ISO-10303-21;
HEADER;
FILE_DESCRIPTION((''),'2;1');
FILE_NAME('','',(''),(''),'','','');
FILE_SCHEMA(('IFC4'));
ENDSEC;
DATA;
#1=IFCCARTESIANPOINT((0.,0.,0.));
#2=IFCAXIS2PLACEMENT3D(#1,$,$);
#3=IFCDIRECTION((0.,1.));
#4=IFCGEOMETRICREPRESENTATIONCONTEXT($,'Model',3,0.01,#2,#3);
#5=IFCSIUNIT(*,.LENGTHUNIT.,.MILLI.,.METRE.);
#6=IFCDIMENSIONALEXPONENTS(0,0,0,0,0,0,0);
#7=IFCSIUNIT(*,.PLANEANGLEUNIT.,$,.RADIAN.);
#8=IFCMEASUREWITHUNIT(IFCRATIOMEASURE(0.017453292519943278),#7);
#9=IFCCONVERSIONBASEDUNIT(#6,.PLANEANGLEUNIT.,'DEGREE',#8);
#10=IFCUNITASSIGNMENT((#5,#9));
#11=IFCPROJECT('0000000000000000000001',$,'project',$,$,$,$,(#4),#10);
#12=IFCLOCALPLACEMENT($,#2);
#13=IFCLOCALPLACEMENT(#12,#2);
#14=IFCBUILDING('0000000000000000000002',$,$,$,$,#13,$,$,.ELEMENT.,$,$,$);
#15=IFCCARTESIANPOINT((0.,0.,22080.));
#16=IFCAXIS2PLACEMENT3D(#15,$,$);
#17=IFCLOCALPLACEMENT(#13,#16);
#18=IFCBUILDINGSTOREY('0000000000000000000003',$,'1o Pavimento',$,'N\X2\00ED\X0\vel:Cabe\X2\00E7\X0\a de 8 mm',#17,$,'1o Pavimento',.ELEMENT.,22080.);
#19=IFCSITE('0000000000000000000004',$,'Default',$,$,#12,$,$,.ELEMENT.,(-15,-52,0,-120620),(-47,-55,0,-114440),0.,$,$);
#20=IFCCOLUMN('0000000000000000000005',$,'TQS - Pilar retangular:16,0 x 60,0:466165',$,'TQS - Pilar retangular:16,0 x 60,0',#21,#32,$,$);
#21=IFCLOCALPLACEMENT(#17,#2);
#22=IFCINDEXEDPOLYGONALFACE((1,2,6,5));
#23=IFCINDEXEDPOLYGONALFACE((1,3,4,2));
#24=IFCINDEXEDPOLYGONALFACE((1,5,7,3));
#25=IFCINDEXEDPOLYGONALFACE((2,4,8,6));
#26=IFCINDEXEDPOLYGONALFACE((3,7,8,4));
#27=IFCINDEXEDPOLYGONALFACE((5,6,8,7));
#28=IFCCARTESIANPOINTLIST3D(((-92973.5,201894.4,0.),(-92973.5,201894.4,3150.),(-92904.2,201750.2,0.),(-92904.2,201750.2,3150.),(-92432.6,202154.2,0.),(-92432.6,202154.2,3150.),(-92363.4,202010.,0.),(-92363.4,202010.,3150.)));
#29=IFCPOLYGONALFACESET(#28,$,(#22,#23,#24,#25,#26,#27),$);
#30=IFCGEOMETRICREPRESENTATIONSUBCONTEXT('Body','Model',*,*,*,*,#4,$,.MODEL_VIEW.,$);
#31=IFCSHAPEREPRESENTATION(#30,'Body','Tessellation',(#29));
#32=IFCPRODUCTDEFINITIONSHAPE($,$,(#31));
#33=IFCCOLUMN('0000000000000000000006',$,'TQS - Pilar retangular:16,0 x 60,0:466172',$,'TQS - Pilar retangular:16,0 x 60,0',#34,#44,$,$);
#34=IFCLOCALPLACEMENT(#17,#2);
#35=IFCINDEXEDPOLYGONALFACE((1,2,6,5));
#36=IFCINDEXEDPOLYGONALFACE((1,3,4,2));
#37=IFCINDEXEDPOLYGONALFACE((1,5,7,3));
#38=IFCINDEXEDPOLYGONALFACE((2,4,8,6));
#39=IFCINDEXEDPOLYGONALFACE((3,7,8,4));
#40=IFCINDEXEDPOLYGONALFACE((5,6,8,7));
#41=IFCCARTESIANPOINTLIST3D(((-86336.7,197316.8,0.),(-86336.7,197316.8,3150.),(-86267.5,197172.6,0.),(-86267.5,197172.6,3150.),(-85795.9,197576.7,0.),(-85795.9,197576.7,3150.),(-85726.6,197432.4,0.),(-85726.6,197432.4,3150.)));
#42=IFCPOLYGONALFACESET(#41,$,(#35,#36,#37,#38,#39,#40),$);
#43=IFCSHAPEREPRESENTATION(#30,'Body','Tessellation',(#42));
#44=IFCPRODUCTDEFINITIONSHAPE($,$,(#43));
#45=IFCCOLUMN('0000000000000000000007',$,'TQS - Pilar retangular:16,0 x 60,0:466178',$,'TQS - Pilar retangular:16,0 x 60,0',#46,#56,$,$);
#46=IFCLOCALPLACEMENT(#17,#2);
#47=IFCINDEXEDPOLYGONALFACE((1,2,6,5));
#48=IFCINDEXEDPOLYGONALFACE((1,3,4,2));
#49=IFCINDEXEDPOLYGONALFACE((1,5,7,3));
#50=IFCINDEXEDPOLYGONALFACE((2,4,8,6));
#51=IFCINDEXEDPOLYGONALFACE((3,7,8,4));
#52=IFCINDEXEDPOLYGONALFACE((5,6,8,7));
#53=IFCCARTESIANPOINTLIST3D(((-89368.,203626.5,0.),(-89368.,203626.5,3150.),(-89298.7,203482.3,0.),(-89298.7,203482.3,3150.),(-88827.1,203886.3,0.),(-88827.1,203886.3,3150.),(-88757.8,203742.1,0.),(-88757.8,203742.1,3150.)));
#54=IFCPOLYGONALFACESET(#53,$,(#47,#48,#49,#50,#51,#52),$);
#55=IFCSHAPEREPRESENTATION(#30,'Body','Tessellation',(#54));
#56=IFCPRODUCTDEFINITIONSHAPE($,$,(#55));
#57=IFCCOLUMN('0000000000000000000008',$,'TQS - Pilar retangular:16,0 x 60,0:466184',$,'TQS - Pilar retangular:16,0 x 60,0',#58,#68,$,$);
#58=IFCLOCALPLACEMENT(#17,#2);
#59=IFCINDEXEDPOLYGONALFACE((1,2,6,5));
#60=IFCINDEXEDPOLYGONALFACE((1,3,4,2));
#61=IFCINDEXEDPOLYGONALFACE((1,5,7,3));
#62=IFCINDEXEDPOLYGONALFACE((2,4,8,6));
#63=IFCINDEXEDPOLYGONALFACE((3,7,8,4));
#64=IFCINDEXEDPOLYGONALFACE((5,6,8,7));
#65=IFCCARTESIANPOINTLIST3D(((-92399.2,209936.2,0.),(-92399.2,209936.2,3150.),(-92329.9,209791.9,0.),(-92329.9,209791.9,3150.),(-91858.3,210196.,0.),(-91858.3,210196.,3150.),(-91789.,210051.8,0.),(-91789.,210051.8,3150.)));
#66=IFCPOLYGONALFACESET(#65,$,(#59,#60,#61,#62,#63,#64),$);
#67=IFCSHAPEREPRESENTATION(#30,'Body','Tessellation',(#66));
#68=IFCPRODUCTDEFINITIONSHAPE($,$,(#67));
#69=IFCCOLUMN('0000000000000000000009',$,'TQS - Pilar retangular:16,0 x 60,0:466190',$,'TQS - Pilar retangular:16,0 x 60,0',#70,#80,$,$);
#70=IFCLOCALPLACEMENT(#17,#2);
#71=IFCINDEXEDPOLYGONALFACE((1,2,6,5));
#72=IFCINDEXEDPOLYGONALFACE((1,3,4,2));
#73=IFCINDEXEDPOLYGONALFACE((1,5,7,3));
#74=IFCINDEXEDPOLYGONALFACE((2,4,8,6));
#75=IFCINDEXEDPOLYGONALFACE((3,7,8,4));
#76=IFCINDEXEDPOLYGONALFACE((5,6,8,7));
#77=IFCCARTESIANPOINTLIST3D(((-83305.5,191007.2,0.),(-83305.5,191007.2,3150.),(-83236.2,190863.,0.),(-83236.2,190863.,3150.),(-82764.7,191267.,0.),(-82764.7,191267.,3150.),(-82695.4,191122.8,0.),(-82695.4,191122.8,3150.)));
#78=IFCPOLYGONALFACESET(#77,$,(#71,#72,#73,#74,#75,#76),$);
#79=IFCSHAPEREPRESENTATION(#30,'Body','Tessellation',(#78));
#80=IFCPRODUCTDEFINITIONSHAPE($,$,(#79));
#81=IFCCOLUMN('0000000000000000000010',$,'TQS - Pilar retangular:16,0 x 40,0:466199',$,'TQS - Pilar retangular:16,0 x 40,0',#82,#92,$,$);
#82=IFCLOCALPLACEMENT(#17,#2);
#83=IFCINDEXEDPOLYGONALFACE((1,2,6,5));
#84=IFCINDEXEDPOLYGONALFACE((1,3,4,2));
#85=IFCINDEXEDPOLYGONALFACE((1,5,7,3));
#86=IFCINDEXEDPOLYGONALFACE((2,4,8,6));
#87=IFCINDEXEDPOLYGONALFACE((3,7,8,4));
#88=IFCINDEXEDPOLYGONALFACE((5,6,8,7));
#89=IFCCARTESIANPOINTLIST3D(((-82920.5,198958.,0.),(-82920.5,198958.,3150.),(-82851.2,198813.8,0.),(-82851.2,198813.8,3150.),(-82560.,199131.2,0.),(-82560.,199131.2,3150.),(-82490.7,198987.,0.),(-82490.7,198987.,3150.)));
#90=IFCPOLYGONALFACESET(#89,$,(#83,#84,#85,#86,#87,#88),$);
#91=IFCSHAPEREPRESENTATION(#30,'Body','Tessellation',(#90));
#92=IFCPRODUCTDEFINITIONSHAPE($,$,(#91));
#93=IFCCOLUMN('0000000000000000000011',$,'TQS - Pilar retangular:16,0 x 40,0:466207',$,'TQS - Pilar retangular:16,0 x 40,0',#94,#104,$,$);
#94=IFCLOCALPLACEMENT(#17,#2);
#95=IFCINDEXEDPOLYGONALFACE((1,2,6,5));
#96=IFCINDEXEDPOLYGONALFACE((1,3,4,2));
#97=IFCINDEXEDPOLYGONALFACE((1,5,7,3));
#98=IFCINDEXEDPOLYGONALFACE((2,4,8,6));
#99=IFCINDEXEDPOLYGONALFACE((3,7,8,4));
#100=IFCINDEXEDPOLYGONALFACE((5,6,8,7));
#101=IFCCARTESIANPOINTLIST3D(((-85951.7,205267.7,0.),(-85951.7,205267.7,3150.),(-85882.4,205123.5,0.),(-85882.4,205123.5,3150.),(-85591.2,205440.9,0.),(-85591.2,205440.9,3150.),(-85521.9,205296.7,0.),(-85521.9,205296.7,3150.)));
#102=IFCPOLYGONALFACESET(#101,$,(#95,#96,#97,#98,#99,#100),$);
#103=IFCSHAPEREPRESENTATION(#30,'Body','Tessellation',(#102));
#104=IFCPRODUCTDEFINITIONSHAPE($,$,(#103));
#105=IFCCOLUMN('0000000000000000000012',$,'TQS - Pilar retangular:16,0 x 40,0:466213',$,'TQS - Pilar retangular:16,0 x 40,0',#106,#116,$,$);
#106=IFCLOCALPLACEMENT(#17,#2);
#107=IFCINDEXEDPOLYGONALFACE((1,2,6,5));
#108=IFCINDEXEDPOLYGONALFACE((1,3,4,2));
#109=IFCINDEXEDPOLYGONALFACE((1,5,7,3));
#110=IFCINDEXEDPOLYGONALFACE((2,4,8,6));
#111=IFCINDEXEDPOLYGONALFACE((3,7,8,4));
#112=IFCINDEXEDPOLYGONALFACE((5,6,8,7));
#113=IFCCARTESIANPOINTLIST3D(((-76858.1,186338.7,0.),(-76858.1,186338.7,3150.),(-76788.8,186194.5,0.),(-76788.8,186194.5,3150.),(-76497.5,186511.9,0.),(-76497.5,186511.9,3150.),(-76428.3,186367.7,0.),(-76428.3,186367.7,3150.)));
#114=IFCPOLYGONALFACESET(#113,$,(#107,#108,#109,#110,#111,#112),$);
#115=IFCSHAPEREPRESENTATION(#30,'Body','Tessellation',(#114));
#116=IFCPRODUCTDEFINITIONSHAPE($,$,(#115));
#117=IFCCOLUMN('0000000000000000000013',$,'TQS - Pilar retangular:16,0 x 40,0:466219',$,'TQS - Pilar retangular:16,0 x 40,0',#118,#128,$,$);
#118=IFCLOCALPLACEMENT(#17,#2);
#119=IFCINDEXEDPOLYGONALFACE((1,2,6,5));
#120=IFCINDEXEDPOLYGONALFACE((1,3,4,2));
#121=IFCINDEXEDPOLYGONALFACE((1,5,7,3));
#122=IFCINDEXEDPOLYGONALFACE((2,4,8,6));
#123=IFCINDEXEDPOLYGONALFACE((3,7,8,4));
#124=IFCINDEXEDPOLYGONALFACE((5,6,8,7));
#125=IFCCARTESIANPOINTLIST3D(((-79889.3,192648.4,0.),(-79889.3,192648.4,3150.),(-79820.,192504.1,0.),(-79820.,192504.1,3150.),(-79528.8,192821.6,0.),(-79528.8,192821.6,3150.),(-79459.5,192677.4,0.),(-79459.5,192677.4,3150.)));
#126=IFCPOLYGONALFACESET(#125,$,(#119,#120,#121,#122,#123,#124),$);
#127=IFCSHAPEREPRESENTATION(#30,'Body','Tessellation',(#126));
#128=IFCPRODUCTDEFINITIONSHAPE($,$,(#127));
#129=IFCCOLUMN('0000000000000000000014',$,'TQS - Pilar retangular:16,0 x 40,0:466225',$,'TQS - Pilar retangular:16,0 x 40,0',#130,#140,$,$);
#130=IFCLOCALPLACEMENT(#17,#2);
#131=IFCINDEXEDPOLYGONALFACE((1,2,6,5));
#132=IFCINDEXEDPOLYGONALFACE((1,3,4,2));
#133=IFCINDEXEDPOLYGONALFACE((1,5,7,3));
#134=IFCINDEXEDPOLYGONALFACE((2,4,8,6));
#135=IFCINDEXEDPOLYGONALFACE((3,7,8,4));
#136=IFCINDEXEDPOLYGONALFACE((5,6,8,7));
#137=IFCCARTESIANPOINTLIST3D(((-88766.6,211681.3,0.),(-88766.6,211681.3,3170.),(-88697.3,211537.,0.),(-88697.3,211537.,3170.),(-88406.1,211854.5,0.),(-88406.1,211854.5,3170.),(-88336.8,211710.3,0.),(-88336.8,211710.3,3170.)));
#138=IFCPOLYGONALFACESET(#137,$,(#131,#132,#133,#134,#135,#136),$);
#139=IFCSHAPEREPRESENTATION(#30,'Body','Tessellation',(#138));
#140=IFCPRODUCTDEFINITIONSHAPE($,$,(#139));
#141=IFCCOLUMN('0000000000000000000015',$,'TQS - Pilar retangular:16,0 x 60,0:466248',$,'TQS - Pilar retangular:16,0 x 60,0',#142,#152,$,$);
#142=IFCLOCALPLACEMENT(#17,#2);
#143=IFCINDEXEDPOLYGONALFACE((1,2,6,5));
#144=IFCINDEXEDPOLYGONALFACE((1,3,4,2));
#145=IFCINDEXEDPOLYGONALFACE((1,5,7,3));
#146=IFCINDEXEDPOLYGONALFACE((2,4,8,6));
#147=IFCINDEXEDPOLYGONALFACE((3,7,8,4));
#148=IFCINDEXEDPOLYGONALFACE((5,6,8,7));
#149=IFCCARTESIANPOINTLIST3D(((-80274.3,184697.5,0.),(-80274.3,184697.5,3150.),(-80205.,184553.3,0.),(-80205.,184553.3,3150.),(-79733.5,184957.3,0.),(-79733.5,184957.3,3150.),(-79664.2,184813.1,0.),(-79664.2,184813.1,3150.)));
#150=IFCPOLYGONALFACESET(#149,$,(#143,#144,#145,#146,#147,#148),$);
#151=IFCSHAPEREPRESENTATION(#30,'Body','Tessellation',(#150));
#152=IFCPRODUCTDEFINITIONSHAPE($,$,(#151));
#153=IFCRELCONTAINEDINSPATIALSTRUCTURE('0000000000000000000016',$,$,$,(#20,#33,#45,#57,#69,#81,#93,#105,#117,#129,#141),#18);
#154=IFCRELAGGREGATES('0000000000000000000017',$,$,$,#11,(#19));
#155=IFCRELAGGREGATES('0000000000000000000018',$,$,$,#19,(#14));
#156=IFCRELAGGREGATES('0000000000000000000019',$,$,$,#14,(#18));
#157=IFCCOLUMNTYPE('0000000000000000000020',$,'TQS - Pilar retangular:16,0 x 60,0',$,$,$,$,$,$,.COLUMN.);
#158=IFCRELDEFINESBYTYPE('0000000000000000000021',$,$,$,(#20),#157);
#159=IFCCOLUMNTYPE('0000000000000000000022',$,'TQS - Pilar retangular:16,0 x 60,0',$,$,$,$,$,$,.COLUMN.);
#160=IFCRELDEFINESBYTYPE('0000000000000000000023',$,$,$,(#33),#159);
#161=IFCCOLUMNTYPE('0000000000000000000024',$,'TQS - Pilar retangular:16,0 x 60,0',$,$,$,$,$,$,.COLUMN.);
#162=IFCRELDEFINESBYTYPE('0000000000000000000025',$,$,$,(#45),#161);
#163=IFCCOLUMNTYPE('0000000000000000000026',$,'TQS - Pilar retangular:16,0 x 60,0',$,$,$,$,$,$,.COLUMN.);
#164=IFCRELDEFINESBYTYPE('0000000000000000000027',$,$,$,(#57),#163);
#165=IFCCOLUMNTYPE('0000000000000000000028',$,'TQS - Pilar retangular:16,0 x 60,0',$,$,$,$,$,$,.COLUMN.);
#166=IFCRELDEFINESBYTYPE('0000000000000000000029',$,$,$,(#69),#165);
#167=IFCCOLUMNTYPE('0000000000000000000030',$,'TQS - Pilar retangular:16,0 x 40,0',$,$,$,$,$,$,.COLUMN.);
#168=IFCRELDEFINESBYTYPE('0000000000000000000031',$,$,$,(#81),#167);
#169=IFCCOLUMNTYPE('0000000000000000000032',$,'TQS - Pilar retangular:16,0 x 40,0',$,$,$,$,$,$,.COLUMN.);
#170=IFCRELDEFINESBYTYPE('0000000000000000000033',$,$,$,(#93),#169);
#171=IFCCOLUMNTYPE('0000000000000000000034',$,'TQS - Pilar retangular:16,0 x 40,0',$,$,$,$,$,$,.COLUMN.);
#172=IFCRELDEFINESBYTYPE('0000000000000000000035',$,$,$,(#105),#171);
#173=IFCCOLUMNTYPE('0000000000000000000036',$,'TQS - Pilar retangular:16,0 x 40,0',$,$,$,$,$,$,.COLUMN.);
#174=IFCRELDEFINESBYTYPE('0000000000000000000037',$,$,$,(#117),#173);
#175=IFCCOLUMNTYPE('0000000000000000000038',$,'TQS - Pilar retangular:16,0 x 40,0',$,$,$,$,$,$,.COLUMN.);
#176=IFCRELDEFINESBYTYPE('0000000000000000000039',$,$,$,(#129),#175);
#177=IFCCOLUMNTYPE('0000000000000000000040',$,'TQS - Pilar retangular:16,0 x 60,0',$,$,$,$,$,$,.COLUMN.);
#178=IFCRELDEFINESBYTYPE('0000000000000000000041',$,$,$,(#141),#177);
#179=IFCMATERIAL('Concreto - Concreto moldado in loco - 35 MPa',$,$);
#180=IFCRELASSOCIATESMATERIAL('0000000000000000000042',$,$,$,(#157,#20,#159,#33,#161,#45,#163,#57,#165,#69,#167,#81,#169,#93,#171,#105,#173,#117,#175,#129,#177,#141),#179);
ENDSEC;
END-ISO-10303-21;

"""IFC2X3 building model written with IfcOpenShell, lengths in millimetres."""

from ifc_helpers import new_model, entity, si_unit, converted_unit, direction, frame, origin, origin_2d_with_axis, place, context, subcontext, project, spatial, rectangle, extrude, source, transform, mapped, material, type_object, type_shapes, element, save


model = new_model("IFC2X3")

# Units and contexts
model_context = context("Model", 3, precision=0.01, world=origin(), true_north=direction((0.0, 1.0)))
body_context = subcontext(model_context, "Body", "Model", "MODEL_VIEW")
ifc_project = project(units=[si_unit("LENGTHUNIT", "METRE", prefix="MILLI"), converted_unit("PLANEANGLEUNIT", "DEGREE", entity("IfcRatioMeasure", 0.017453292519943278), si_unit("PLANEANGLEUNIT", "RADIAN"), dimensions=[0, 0, 0, 0, 0, 0, 0])], contexts=[model_context])

# Site, building, storey
site_placement = place(None, origin())
site = spatial("IfcSite", under=ifc_project, at=site_placement, Name="Default", CompositionType="ELEMENT", RefLatitude=(-15, -52, 0, -120620), RefLongitude=(-47, -55, 0, -114440), RefElevation=0.0)
building_placement = place(site_placement, origin())
building = spatial("IfcBuilding", under=site, at=building_placement, CompositionType="ELEMENT")
storey_placement = place(building_placement, frame((0.0, 0.0, 22080.0)))
storey = spatial("IfcBuildingStorey", under=building, at=storey_placement, Name="1o Pavimento", ObjectType="Nível:Cabeça de 8 mm", LongName="1o Pavimento", CompositionType="ELEMENT", Elevation=22080.0)

# Columns
ifc_material = material(Name="Concreto - Concreto moldado in loco - 35 MPa")
column_type_1 = type_object("IfcColumnType", Name="TQS - Pilar retangular:16,0 x 60,0", PredefinedType="COLUMN", material=ifc_material)
shared_shape_1 = source(origin(), body_context, "Body", "SweptSolid", [
    extrude(rectangle(XDim=600.0, YDim=160.0, at=origin_2d_with_axis()), frame((-92668.4, 201952.2, 22080.0), z_axis=(0.0, 0.0, 1.0), x_axis=(-0.90138, -0.43303, 0.0)), (0.0, 0.0, 1.0), 3150.0),
])
type_shapes(column_type_1, [shared_shape_1])
column_1_placement = place(storey_placement, frame((0.0, 0.0, -22080.0)))
element("IfcColumn", 1, at=column_1_placement, inside=storey, type_object=column_type_1, material=ifc_material, Name="TQS - Pilar retangular:16,0 x 60,0:466165", ObjectType="TQS - Pilar retangular:16,0 x 60,0", context=body_context, shape_type="MappedRepresentation", body=[
    mapped(shared_shape_1, transform((0.0, 0.0, 0.0), scale=1.0)),
])
column_type_2 = type_object("IfcColumnType", Name="TQS - Pilar retangular:16,0 x 60,0", PredefinedType="COLUMN", material=ifc_material)
shared_shape_2 = source(origin(), body_context, "Body", "SweptSolid", [
    extrude(rectangle(XDim=600.0, YDim=160.0, at=origin_2d_with_axis()), frame((-86031.7, 197374.6, 22080.0), z_axis=(0.0, 0.0, 1.0), x_axis=(-0.90138, -0.43303, 0.0)), (0.0, 0.0, 1.0), 3150.0),
])
type_shapes(column_type_2, [shared_shape_2])
column_2_placement = place(storey_placement, frame((0.0, 0.0, -22080.0)))
element("IfcColumn", 2, at=column_2_placement, inside=storey, type_object=column_type_2, material=ifc_material, Name="TQS - Pilar retangular:16,0 x 60,0:466172", ObjectType="TQS - Pilar retangular:16,0 x 60,0", context=body_context, shape_type="MappedRepresentation", body=[
    mapped(shared_shape_2, transform((0.0, 0.0, 0.0), scale=1.0)),
])
column_type_3 = type_object("IfcColumnType", Name="TQS - Pilar retangular:16,0 x 60,0", PredefinedType="COLUMN", material=ifc_material)
shared_shape_3 = source(origin(), body_context, "Body", "SweptSolid", [
    extrude(rectangle(XDim=600.0, YDim=160.0, at=origin_2d_with_axis()), frame((-89062.9, 203684.3, 22080.0), z_axis=(0.0, 0.0, 1.0), x_axis=(-0.90138, -0.43303, 0.0)), (0.0, 0.0, 1.0), 3150.0),
])
type_shapes(column_type_3, [shared_shape_3])
column_3_placement = place(storey_placement, frame((0.0, 0.0, -22080.0)))
element("IfcColumn", 3, at=column_3_placement, inside=storey, type_object=column_type_3, material=ifc_material, Name="TQS - Pilar retangular:16,0 x 60,0:466178", ObjectType="TQS - Pilar retangular:16,0 x 60,0", context=body_context, shape_type="MappedRepresentation", body=[
    mapped(shared_shape_3, transform((0.0, 0.0, 0.0), scale=1.0)),
])
column_type_4 = type_object("IfcColumnType", Name="TQS - Pilar retangular:16,0 x 60,0", PredefinedType="COLUMN", material=ifc_material)
shared_shape_4 = source(origin(), body_context, "Body", "SweptSolid", [
    extrude(rectangle(XDim=600.0, YDim=160.0, at=origin_2d_with_axis()), frame((-92094.1, 209994.0, 22080.0), z_axis=(0.0, 0.0, 1.0), x_axis=(-0.90138, -0.43303, 0.0)), (0.0, 0.0, 1.0), 3150.0),
])
type_shapes(column_type_4, [shared_shape_4])
column_4_placement = place(storey_placement, frame((0.0, 0.0, -22080.0)))
element("IfcColumn", 4, at=column_4_placement, inside=storey, type_object=column_type_4, material=ifc_material, Name="TQS - Pilar retangular:16,0 x 60,0:466184", ObjectType="TQS - Pilar retangular:16,0 x 60,0", context=body_context, shape_type="MappedRepresentation", body=[
    mapped(shared_shape_4, transform((0.0, 0.0, 0.0), scale=1.0)),
])
column_type_5 = type_object("IfcColumnType", Name="TQS - Pilar retangular:16,0 x 60,0", PredefinedType="COLUMN", material=ifc_material)
shared_shape_5 = source(origin(), body_context, "Body", "SweptSolid", [
    extrude(rectangle(XDim=600.0, YDim=160.0, at=origin_2d_with_axis()), frame((-83000.5, 191065.0, 22080.0), z_axis=(0.0, 0.0, 1.0), x_axis=(-0.90138, -0.43303, 0.0)), (0.0, 0.0, 1.0), 3150.0),
])
type_shapes(column_type_5, [shared_shape_5])
column_5_placement = place(storey_placement, frame((0.0, 0.0, -22080.0)))
element("IfcColumn", 5, at=column_5_placement, inside=storey, type_object=column_type_5, material=ifc_material, Name="TQS - Pilar retangular:16,0 x 60,0:466190", ObjectType="TQS - Pilar retangular:16,0 x 60,0", context=body_context, shape_type="MappedRepresentation", body=[
    mapped(shared_shape_5, transform((0.0, 0.0, 0.0), scale=1.0)),
])
column_type_6 = type_object("IfcColumnType", Name="TQS - Pilar retangular:16,0 x 40,0", PredefinedType="COLUMN", material=ifc_material)
shared_shape_6 = source(origin(), body_context, "Body", "SweptSolid", [
    extrude(rectangle(XDim=400.0, YDim=160.0, at=origin_2d_with_axis()), frame((-82705.6, 198972.5, 22080.0), z_axis=(0.0, 0.0, 1.0), x_axis=(-0.90138, -0.43303, 0.0)), (0.0, 0.0, 1.0), 3150.0),
])
type_shapes(column_type_6, [shared_shape_6])
column_6_placement = place(storey_placement, frame((0.0, 0.0, -22080.0)))
element("IfcColumn", 6, at=column_6_placement, inside=storey, type_object=column_type_6, material=ifc_material, Name="TQS - Pilar retangular:16,0 x 40,0:466199", ObjectType="TQS - Pilar retangular:16,0 x 40,0", context=body_context, shape_type="MappedRepresentation", body=[
    mapped(shared_shape_6, transform((0.0, 0.0, 0.0), scale=1.0)),
])
column_type_7 = type_object("IfcColumnType", Name="TQS - Pilar retangular:16,0 x 40,0", PredefinedType="COLUMN", material=ifc_material)
shared_shape_7 = source(origin(), body_context, "Body", "SweptSolid", [
    extrude(rectangle(XDim=400.0, YDim=160.0, at=origin_2d_with_axis()), frame((-85736.8, 205282.2, 22080.0), z_axis=(0.0, 0.0, 1.0), x_axis=(-0.90138, -0.43303, 0.0)), (0.0, 0.0, 1.0), 3150.0),
])
type_shapes(column_type_7, [shared_shape_7])
column_7_placement = place(storey_placement, frame((0.0, 0.0, -22080.0)))
element("IfcColumn", 7, at=column_7_placement, inside=storey, type_object=column_type_7, material=ifc_material, Name="TQS - Pilar retangular:16,0 x 40,0:466207", ObjectType="TQS - Pilar retangular:16,0 x 40,0", context=body_context, shape_type="MappedRepresentation", body=[
    mapped(shared_shape_7, transform((0.0, 0.0, 0.0), scale=1.0)),
])
column_type_8 = type_object("IfcColumnType", Name="TQS - Pilar retangular:16,0 x 40,0", PredefinedType="COLUMN", material=ifc_material)
shared_shape_8 = source(origin(), body_context, "Body", "SweptSolid", [
    extrude(rectangle(XDim=400.0, YDim=160.0, at=origin_2d_with_axis()), frame((-76643.2, 186353.2, 22080.0), z_axis=(0.0, 0.0, 1.0), x_axis=(-0.90138, -0.43303, 0.0)), (0.0, 0.0, 1.0), 3150.0),
])
type_shapes(column_type_8, [shared_shape_8])
column_8_placement = place(storey_placement, frame((0.0, 0.0, -22080.0)))
element("IfcColumn", 8, at=column_8_placement, inside=storey, type_object=column_type_8, material=ifc_material, Name="TQS - Pilar retangular:16,0 x 40,0:466213", ObjectType="TQS - Pilar retangular:16,0 x 40,0", context=body_context, shape_type="MappedRepresentation", body=[
    mapped(shared_shape_8, transform((0.0, 0.0, 0.0), scale=1.0)),
])
column_type_9 = type_object("IfcColumnType", Name="TQS - Pilar retangular:16,0 x 40,0", PredefinedType="COLUMN", material=ifc_material)
shared_shape_9 = source(origin(), body_context, "Body", "SweptSolid", [
    extrude(rectangle(XDim=400.0, YDim=160.0, at=origin_2d_with_axis()), frame((-79674.4, 192662.9, 22080.0), z_axis=(0.0, 0.0, 1.0), x_axis=(-0.90138, -0.43303, 0.0)), (0.0, 0.0, 1.0), 3150.0),
])
type_shapes(column_type_9, [shared_shape_9])
column_9_placement = place(storey_placement, frame((0.0, 0.0, -22080.0)))
element("IfcColumn", 9, at=column_9_placement, inside=storey, type_object=column_type_9, material=ifc_material, Name="TQS - Pilar retangular:16,0 x 40,0:466219", ObjectType="TQS - Pilar retangular:16,0 x 40,0", context=body_context, shape_type="MappedRepresentation", body=[
    mapped(shared_shape_9, transform((0.0, 0.0, 0.0), scale=1.0)),
])
column_type_10 = type_object("IfcColumnType", Name="TQS - Pilar retangular:16,0 x 40,0", PredefinedType="COLUMN", material=ifc_material)
shared_shape_10 = source(origin(), body_context, "Body", "SweptSolid", [
    extrude(rectangle(XDim=400.0, YDim=160.0, at=origin_2d_with_axis()), frame((-88551.7, 211695.8, 22080.0), z_axis=(0.0, 0.0, 1.0), x_axis=(-0.90138, -0.43303, 0.0)), (0.0, 0.0, 1.0), 3170.0),
])
type_shapes(column_type_10, [shared_shape_10])
column_10_placement = place(storey_placement, frame((0.0, 0.0, -22080.0)))
element("IfcColumn", 10, at=column_10_placement, inside=storey, type_object=column_type_10, material=ifc_material, Name="TQS - Pilar retangular:16,0 x 40,0:466225", ObjectType="TQS - Pilar retangular:16,0 x 40,0", context=body_context, shape_type="MappedRepresentation", body=[
    mapped(shared_shape_10, transform((0.0, 0.0, 0.0), scale=1.0)),
])
column_type_11 = type_object("IfcColumnType", Name="TQS - Pilar retangular:16,0 x 60,0", PredefinedType="COLUMN", material=ifc_material)
shared_shape_11 = source(origin(), body_context, "Body", "SweptSolid", [
    extrude(rectangle(XDim=600.0, YDim=160.0, at=origin_2d_with_axis()), frame((-79969.3, 184755.3, 22080.0), z_axis=(0.0, 0.0, 1.0), x_axis=(-0.90138, -0.43303, 0.0)), (0.0, 0.0, 1.0), 3150.0),
])
type_shapes(column_type_11, [shared_shape_11])
column_11_placement = place(storey_placement, frame((0.0, 0.0, -22080.0)))
element("IfcColumn", 11, at=column_11_placement, inside=storey, type_object=column_type_11, material=ifc_material, Name="TQS - Pilar retangular:16,0 x 60,0:466248", ObjectType="TQS - Pilar retangular:16,0 x 60,0", context=body_context, shape_type="MappedRepresentation", body=[
    mapped(shared_shape_11, transform((0.0, 0.0, 0.0), scale=1.0)),
])

save(model, "model.ifc")
